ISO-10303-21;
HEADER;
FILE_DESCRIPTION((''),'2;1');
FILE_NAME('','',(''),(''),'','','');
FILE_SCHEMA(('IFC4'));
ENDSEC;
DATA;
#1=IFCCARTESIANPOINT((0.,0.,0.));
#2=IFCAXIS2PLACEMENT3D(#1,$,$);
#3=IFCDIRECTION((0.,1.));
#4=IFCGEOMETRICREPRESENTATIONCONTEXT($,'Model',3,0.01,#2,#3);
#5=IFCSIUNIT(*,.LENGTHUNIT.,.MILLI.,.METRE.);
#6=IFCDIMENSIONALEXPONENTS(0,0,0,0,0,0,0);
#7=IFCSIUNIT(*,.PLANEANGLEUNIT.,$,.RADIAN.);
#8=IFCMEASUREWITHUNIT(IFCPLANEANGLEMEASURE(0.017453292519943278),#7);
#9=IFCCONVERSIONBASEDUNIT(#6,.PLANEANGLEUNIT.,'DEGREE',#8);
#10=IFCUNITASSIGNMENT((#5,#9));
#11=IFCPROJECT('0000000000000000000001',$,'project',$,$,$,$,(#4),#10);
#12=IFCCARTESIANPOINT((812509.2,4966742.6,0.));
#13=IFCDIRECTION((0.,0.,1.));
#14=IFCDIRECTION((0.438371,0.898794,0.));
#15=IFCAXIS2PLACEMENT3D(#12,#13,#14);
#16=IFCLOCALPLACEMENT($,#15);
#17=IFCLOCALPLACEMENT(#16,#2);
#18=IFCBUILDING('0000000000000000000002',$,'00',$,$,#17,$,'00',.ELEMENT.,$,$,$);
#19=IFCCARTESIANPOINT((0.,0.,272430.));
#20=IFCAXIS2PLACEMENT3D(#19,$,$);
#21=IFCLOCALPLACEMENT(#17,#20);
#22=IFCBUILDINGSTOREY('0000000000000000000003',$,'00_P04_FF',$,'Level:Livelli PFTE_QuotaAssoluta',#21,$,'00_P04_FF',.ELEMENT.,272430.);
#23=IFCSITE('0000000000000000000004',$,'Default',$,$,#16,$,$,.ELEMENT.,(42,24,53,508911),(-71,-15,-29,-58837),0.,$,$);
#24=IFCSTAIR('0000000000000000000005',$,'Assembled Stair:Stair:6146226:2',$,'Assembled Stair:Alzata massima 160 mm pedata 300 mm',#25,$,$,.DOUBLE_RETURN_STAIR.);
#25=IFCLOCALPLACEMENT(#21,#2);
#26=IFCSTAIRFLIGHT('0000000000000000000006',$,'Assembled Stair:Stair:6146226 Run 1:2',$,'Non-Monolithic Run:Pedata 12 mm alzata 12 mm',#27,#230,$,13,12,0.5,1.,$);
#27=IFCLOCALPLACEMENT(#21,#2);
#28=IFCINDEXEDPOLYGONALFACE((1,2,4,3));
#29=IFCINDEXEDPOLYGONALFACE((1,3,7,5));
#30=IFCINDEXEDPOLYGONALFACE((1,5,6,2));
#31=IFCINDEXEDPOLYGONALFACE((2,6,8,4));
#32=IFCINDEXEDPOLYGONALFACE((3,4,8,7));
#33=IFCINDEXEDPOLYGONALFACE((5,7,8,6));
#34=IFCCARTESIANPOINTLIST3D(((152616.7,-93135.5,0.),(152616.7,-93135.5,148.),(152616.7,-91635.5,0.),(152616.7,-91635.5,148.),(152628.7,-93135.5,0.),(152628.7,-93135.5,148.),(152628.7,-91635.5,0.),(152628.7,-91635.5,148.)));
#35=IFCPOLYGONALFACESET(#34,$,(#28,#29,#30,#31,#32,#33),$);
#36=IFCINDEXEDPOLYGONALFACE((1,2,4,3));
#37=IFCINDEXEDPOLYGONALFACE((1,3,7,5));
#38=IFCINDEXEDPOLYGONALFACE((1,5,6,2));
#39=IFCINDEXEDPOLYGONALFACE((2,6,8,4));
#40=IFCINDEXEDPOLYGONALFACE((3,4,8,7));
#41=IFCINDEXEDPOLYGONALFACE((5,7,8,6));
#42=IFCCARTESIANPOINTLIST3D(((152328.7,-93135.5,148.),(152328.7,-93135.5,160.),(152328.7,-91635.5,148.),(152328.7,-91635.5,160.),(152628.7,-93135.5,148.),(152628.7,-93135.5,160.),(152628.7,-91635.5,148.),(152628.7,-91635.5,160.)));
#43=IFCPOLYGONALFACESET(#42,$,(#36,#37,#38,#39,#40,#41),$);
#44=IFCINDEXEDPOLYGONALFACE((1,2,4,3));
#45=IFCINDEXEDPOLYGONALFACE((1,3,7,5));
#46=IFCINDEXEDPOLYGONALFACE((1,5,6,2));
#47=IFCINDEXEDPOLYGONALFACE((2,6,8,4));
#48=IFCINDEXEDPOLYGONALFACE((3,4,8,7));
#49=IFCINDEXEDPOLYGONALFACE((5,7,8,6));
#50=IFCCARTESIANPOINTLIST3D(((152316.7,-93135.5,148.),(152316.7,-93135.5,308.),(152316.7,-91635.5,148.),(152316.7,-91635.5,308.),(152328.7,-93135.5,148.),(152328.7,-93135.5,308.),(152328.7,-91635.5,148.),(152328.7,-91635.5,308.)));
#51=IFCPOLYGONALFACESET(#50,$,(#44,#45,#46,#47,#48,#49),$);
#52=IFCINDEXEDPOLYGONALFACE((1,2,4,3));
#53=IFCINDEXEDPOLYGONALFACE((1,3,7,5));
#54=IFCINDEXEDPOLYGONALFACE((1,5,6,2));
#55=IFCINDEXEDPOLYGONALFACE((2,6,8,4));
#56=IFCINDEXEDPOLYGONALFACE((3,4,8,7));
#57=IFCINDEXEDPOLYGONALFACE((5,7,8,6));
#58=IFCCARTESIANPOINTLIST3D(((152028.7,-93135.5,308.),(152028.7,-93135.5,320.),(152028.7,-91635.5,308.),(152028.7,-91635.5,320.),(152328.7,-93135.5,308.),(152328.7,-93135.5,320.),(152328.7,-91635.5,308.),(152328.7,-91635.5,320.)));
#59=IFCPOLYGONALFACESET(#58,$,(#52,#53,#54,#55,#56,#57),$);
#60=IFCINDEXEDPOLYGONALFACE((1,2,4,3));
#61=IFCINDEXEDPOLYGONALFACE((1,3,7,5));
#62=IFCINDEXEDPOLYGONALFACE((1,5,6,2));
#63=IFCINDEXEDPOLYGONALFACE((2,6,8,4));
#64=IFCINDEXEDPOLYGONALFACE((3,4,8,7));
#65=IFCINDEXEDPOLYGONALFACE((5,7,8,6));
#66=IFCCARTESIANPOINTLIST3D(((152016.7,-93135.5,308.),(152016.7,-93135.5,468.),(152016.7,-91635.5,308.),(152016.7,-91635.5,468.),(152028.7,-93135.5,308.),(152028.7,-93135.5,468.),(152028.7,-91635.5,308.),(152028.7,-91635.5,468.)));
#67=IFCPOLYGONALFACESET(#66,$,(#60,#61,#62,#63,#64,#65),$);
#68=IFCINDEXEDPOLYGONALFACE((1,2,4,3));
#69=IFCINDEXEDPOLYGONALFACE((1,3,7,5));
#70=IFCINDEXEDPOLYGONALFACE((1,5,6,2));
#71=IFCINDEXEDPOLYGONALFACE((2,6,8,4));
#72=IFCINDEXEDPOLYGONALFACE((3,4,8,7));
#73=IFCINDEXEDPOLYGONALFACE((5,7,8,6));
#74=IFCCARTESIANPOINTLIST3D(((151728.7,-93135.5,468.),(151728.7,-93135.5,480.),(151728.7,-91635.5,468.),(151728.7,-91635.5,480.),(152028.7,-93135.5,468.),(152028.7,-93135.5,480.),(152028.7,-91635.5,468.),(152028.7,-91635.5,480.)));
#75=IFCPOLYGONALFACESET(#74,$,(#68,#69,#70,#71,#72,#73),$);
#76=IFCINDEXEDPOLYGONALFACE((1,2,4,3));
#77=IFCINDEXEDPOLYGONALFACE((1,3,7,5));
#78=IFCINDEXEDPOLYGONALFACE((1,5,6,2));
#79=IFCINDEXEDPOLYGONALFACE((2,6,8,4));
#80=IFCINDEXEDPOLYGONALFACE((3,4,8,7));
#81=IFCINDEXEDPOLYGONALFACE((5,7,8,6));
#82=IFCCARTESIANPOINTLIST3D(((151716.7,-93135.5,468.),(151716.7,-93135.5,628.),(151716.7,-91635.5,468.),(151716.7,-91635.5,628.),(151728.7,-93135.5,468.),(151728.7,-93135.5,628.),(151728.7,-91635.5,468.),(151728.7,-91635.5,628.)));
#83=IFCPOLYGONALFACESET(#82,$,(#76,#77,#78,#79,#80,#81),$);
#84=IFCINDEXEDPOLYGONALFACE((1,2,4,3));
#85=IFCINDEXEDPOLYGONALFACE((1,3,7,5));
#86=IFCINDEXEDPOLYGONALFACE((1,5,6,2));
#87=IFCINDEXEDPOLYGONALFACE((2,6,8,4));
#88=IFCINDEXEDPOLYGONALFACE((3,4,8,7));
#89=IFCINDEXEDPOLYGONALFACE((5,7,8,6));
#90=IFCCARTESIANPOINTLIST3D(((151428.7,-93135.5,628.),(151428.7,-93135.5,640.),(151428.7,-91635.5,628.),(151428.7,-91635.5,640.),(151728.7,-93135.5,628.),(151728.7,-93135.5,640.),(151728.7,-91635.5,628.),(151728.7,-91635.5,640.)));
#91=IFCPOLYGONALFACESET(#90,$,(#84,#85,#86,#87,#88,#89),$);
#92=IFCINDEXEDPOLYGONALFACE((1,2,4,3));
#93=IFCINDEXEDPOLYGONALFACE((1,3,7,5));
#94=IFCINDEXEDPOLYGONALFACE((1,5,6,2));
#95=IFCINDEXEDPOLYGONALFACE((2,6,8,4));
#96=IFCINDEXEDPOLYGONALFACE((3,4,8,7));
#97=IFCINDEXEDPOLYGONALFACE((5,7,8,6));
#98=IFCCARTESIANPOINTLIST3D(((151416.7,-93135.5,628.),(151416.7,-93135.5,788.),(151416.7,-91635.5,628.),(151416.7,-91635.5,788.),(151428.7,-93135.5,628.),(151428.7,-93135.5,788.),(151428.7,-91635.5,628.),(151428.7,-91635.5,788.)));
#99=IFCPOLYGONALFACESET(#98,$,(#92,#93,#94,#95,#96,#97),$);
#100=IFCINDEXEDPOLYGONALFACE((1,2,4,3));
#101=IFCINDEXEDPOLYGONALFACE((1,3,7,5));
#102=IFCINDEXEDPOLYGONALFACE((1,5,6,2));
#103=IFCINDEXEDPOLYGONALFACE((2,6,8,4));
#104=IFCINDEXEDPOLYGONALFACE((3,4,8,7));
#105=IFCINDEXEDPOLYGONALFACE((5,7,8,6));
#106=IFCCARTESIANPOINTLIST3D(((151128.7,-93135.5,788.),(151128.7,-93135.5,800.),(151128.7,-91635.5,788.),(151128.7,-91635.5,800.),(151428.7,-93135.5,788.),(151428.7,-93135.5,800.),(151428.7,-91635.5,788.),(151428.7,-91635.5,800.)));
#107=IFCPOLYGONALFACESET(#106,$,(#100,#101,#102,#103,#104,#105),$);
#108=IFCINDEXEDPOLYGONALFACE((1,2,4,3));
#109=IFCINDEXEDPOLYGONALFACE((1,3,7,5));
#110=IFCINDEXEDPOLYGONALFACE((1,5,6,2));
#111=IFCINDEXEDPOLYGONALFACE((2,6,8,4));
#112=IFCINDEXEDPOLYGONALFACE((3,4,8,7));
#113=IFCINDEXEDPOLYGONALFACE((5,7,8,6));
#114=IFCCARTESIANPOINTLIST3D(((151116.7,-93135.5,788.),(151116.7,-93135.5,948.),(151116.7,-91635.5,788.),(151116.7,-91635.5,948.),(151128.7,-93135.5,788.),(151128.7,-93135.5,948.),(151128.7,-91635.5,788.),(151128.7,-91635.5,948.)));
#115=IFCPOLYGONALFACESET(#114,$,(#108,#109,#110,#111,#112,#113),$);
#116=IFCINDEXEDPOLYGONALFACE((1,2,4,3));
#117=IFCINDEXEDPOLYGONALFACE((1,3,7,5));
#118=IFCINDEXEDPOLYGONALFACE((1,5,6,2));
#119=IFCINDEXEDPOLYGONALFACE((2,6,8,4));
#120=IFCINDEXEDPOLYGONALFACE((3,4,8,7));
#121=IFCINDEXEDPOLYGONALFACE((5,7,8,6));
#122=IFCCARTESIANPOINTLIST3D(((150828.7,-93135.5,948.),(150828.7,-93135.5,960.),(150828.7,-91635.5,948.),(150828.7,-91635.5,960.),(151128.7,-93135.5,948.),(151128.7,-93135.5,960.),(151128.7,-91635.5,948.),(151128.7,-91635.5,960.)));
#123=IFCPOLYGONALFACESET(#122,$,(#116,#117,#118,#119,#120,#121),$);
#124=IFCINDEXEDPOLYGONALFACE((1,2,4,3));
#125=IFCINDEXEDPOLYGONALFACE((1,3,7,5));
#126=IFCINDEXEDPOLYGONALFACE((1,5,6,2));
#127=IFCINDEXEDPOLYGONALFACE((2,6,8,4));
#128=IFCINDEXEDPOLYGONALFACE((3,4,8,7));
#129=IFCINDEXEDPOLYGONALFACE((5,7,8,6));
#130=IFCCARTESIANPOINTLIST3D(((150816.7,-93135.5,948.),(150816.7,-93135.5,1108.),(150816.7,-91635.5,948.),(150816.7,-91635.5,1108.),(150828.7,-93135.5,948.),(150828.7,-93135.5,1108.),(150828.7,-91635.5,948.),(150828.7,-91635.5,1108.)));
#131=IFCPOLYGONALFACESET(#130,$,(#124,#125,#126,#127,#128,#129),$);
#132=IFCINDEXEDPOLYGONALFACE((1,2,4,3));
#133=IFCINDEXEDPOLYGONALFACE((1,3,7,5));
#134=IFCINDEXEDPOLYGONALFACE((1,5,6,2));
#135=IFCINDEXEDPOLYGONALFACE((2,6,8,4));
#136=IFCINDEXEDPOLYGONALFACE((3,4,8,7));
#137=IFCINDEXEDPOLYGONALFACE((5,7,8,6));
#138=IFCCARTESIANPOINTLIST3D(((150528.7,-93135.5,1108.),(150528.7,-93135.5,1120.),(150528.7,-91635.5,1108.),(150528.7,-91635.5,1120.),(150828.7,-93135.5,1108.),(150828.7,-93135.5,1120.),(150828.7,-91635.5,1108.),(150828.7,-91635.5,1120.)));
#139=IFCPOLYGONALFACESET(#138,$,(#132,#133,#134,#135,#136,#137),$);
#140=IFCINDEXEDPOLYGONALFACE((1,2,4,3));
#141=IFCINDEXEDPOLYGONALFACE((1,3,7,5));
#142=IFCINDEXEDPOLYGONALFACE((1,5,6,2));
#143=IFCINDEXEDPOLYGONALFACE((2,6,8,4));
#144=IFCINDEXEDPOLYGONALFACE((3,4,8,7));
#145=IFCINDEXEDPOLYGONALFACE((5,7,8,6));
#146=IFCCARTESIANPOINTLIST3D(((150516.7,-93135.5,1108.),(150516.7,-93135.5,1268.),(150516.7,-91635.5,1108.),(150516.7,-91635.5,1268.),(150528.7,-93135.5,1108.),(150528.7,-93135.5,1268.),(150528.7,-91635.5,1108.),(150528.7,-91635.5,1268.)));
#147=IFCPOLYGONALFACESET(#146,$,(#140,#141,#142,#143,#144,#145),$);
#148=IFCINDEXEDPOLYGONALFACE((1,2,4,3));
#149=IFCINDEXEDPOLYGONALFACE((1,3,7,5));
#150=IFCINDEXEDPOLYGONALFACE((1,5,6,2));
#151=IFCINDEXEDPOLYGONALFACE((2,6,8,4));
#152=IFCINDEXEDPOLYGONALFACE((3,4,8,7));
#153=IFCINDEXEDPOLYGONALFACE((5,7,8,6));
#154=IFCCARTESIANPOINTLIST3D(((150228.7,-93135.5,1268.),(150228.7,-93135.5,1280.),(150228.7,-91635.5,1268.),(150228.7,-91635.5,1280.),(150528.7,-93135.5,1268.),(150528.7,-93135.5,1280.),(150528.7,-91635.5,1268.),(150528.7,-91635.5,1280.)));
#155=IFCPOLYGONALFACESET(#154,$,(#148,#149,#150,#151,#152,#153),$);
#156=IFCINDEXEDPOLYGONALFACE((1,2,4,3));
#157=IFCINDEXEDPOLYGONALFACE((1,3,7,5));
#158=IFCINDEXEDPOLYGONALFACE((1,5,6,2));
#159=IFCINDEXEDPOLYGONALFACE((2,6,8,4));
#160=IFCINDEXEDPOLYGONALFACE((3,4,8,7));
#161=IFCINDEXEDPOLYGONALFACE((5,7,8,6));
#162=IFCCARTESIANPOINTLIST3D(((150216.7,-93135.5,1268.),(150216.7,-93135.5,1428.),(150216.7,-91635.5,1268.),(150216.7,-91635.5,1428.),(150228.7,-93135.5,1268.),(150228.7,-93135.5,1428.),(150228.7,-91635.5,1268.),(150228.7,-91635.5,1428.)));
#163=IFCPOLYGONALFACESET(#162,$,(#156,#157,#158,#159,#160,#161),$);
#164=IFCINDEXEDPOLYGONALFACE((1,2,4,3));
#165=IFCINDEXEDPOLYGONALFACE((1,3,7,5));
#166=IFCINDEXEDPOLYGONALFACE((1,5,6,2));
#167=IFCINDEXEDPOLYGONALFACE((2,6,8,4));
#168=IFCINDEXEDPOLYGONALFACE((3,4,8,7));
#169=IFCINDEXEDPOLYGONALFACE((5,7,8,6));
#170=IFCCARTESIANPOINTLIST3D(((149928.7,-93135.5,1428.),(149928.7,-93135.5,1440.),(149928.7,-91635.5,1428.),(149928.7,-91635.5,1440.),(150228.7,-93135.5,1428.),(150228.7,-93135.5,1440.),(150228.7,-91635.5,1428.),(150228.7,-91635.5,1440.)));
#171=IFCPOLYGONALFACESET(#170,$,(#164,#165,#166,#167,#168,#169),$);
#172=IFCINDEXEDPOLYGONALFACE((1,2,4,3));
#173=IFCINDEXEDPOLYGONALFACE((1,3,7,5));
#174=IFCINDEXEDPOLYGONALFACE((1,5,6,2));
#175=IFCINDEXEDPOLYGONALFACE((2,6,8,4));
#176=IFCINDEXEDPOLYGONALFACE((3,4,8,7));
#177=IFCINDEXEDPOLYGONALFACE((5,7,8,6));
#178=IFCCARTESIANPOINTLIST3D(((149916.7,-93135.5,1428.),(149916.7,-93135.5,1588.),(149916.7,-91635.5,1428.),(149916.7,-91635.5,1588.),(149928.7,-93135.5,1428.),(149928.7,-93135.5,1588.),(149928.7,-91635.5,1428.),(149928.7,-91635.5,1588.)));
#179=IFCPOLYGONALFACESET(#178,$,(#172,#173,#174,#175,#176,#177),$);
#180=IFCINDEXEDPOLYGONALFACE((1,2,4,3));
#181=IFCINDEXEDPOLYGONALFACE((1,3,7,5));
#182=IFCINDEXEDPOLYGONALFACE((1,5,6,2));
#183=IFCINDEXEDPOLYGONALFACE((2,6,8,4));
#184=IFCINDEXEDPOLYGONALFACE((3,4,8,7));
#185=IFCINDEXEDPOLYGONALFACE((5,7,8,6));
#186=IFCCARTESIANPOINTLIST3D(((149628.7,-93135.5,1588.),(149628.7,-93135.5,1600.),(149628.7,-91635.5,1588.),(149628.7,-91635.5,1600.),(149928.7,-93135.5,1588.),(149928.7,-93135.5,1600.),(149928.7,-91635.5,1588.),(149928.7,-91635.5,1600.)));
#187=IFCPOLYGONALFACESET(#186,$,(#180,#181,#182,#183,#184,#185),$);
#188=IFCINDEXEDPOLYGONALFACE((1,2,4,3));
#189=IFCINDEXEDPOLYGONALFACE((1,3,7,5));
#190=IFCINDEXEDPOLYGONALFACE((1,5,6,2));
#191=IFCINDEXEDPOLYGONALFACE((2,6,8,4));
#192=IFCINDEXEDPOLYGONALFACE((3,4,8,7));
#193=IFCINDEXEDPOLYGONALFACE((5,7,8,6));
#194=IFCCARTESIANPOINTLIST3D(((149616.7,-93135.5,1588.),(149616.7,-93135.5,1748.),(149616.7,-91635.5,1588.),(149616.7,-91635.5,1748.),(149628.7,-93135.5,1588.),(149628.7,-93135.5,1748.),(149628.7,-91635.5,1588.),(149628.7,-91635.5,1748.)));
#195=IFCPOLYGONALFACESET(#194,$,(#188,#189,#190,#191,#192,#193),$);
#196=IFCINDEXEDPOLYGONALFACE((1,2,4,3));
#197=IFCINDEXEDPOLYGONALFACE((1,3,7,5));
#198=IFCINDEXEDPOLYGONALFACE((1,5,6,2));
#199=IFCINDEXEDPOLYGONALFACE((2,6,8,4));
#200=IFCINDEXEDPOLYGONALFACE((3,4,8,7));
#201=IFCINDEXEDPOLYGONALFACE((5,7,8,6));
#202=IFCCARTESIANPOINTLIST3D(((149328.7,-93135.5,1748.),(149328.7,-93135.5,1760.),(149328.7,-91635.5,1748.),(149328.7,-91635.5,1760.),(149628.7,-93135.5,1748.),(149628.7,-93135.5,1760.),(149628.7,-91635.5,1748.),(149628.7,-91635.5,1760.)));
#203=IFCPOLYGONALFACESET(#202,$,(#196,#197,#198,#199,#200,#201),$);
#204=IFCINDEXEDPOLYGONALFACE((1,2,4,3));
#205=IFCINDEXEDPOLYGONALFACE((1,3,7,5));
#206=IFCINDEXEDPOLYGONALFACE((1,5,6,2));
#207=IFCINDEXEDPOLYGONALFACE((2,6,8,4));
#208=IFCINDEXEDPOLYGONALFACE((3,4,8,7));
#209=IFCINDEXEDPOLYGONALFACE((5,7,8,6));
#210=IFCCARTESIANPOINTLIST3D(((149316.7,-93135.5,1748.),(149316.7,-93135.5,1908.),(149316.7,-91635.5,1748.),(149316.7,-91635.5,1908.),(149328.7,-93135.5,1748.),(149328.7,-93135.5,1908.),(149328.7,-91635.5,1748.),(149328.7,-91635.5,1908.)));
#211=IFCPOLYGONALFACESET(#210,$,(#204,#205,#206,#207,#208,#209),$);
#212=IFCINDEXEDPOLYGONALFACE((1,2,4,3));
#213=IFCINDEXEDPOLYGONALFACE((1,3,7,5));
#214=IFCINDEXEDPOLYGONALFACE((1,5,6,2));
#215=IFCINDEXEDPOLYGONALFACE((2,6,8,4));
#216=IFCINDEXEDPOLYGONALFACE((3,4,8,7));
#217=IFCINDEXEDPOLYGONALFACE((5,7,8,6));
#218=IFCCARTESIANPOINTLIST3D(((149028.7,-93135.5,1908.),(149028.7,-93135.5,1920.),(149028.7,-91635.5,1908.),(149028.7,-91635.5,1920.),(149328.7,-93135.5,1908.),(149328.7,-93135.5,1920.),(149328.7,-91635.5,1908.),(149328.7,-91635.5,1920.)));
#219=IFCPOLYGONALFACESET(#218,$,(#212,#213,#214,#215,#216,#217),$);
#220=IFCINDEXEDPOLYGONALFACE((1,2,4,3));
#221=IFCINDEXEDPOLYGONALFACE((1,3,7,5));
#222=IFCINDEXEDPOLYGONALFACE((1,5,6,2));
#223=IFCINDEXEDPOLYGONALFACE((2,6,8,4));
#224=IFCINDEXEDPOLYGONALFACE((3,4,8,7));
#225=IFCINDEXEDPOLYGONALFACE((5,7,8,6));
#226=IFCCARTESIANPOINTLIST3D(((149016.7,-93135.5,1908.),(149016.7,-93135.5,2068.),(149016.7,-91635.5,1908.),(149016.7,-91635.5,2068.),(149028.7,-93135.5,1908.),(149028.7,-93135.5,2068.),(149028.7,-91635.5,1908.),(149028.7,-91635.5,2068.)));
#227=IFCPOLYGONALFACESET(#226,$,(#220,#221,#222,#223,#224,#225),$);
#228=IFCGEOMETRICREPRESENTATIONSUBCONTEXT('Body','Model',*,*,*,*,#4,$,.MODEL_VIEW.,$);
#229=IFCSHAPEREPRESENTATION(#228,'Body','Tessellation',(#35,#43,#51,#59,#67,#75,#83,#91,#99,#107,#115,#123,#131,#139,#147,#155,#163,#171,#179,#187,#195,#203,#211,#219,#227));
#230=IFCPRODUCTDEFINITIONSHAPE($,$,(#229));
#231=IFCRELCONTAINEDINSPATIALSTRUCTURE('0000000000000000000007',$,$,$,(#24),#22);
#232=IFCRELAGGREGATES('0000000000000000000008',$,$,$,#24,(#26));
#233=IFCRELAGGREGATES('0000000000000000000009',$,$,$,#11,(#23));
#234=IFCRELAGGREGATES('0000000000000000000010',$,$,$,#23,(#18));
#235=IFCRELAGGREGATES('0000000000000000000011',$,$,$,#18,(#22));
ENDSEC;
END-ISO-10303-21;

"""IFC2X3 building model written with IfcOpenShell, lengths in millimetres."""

from ifc_helpers import new_model, entity, si_unit, converted_unit, direction, frame, frame_2d, origin, origin_2d_with_axis, place, context, subcontext, project, spatial, rectangle, extrude, element, aggregate, save


model = new_model("IFC2X3")

# Units and contexts
model_context = context("Model", 3, precision=0.01, world=origin(), true_north=direction((0.0, 1.0)))
body_context = subcontext(model_context, "Body", "Model", "MODEL_VIEW")
ifc_project = project(units=[si_unit("LENGTHUNIT", "METRE", prefix="MILLI"), converted_unit("PLANEANGLEUNIT", "DEGREE", entity("IfcPlaneAngleMeasure", 0.017453292519943278), si_unit("PLANEANGLEUNIT", "RADIAN"), dimensions=[0, 0, 0, 0, 0, 0, 0])], contexts=[model_context])

# Site, building, storey
site_placement = place(None, frame((812509.2, 4966742.6, 0.0), z_axis=(0.0, 0.0, 1.0), x_axis=(0.438371, 0.898794, 0.0)))
site = spatial("IfcSite", under=ifc_project, at=site_placement, Name="Default", CompositionType="ELEMENT", RefLatitude=(42, 24, 53, 508911), RefLongitude=(-71, -15, -29, -58837), RefElevation=0.0)
building_placement = place(site_placement, origin())
building = spatial("IfcBuilding", under=site, at=building_placement, Name="00", LongName="00", CompositionType="ELEMENT")
storey_placement = place(building_placement, frame((0.0, 0.0, 272430.0)))
storey = spatial("IfcBuildingStorey", under=building, at=storey_placement, Name="00_P04_FF", ObjectType="Level:Livelli PFTE_QuotaAssoluta", LongName="00_P04_FF", CompositionType="ELEMENT", Elevation=272430.0)

# Stair
stair_1_placement = place(storey_placement, origin())
stair_1 = element("IfcStair", 1, at=stair_1_placement, inside=storey, Name="Assembled Stair:Stair:6146226:2", ObjectType="Assembled Stair:Alzata massima 160 mm pedata 300 mm", ShapeType="DOUBLE_RETURN_STAIR")

# Stair flight
stair_flight_1_placement = place(stair_1_placement, origin())
stair_flight_1 = element("IfcStairFlight", 2, at=stair_flight_1_placement, Name="Assembled Stair:Stair:6146226 Run 1:2", ObjectType="Non-Monolithic Run:Pedata 12 mm alzata 12 mm", NumberOfRiser=13, NumberOfTreads=12, RiserHeight=0.5, TreadLength=1.0, context=body_context, shape_type="SweptSolid", body=[
    extrude(rectangle(XDim=1500.0, YDim=12.0, at=frame_2d((0.0, 0.0), x_axis=(1.0, 0.0))), frame((152622.7, -92385.5, 0.0), z_axis=(0.0, 0.0, 1.0), x_axis=(0.0, -1.0, 0.0)), (0.0, 0.0, 1.0), 148.0),
    extrude(rectangle(XDim=300.0, YDim=1500.0, at=frame_2d((0.0, 0.0), x_axis=(1.0, 0.0))), frame((152478.7, -92385.5, 148.0)), (0.0, 0.0, 1.0), 12.0),
    extrude(rectangle(XDim=1500.0, YDim=12.0, at=origin_2d_with_axis()), frame((152322.7, -92385.5, 148.0), z_axis=(0.0, 0.0, 1.0), x_axis=(0.0, -1.0, 0.0)), (0.0, 0.0, 1.0), 160.0),
    extrude(rectangle(XDim=300.0, YDim=1500.0, at=origin_2d_with_axis()), frame((152178.7, -92385.5, 308.0)), (0.0, 0.0, 1.0), 12.0),
    extrude(rectangle(XDim=1500.0, YDim=12.0, at=origin_2d_with_axis()), frame((152022.7, -92385.5, 308.0), z_axis=(0.0, 0.0, 1.0), x_axis=(0.0, -1.0, 0.0)), (0.0, 0.0, 1.0), 160.0),
    extrude(rectangle(XDim=300.0, YDim=1500.0, at=origin_2d_with_axis()), frame((151878.7, -92385.5, 468.0)), (0.0, 0.0, 1.0), 12.0),
    extrude(rectangle(XDim=1500.0, YDim=12.0, at=origin_2d_with_axis()), frame((151722.7, -92385.5, 468.0), z_axis=(0.0, 0.0, 1.0), x_axis=(0.0, -1.0, 0.0)), (0.0, 0.0, 1.0), 160.0),
    extrude(rectangle(XDim=300.0, YDim=1500.0, at=origin_2d_with_axis()), frame((151578.7, -92385.5, 628.0)), (0.0, 0.0, 1.0), 12.0),
    extrude(rectangle(XDim=1500.0, YDim=12.0, at=origin_2d_with_axis()), frame((151422.7, -92385.5, 628.0), z_axis=(0.0, 0.0, 1.0), x_axis=(0.0, -1.0, 0.0)), (0.0, 0.0, 1.0), 160.0),
    extrude(rectangle(XDim=300.0, YDim=1500.0, at=origin_2d_with_axis()), frame((151278.7, -92385.5, 788.0)), (0.0, 0.0, 1.0), 12.0),
    extrude(rectangle(XDim=1500.0, YDim=12.0, at=origin_2d_with_axis()), frame((151122.7, -92385.5, 788.0), z_axis=(0.0, 0.0, 1.0), x_axis=(0.0, -1.0, 0.0)), (0.0, 0.0, 1.0), 160.0),
    extrude(rectangle(XDim=300.0, YDim=1500.0, at=origin_2d_with_axis()), frame((150978.7, -92385.5, 948.0)), (0.0, 0.0, 1.0), 12.0),
    extrude(rectangle(XDim=1500.0, YDim=12.0, at=origin_2d_with_axis()), frame((150822.7, -92385.5, 948.0), z_axis=(0.0, 0.0, 1.0), x_axis=(0.0, -1.0, 0.0)), (0.0, 0.0, 1.0), 160.0),
    extrude(rectangle(XDim=300.0, YDim=1500.0, at=origin_2d_with_axis()), frame((150678.7, -92385.5, 1108.0)), (0.0, 0.0, 1.0), 12.0),
    extrude(rectangle(XDim=1500.0, YDim=12.0, at=origin_2d_with_axis()), frame((150522.7, -92385.5, 1108.0), z_axis=(0.0, 0.0, 1.0), x_axis=(0.0, -1.0, 0.0)), (0.0, 0.0, 1.0), 160.0),
    extrude(rectangle(XDim=300.0, YDim=1500.0, at=origin_2d_with_axis()), frame((150378.7, -92385.5, 1268.0)), (0.0, 0.0, 1.0), 12.0),
    extrude(rectangle(XDim=1500.0, YDim=12.0, at=origin_2d_with_axis()), frame((150222.7, -92385.5, 1268.0), z_axis=(0.0, 0.0, 1.0), x_axis=(0.0, -1.0, 0.0)), (0.0, 0.0, 1.0), 160.0),
    extrude(rectangle(XDim=300.0, YDim=1500.0, at=origin_2d_with_axis()), frame((150078.7, -92385.5, 1428.0)), (0.0, 0.0, 1.0), 12.0),
    extrude(rectangle(XDim=1500.0, YDim=12.0, at=origin_2d_with_axis()), frame((149922.7, -92385.5, 1428.0), z_axis=(0.0, 0.0, 1.0), x_axis=(0.0, -1.0, 0.0)), (0.0, 0.0, 1.0), 160.0),
    extrude(rectangle(XDim=300.0, YDim=1500.0, at=origin_2d_with_axis()), frame((149778.7, -92385.5, 1588.0)), (0.0, 0.0, 1.0), 12.0),
    extrude(rectangle(XDim=1500.0, YDim=12.0, at=origin_2d_with_axis()), frame((149622.7, -92385.5, 1588.0), z_axis=(0.0, 0.0, 1.0), x_axis=(0.0, -1.0, 0.0)), (0.0, 0.0, 1.0), 160.0),
    extrude(rectangle(XDim=300.0, YDim=1500.0, at=origin_2d_with_axis()), frame((149478.7, -92385.5, 1748.0)), (0.0, 0.0, 1.0), 12.0),
    extrude(rectangle(XDim=1500.0, YDim=12.0, at=origin_2d_with_axis()), frame((149322.7, -92385.5, 1748.0), z_axis=(0.0, 0.0, 1.0), x_axis=(0.0, -1.0, 0.0)), (0.0, 0.0, 1.0), 160.0),
    extrude(rectangle(XDim=300.0, YDim=1500.0, at=origin_2d_with_axis()), frame((149178.7, -92385.5, 1908.0)), (0.0, 0.0, 1.0), 12.0),
    extrude(rectangle(XDim=1500.0, YDim=12.0, at=origin_2d_with_axis()), frame((149022.7, -92385.5, 1908.0), z_axis=(0.0, 0.0, 1.0), x_axis=(0.0, -1.0, 0.0)), (0.0, 0.0, 1.0), 160.0),
])
aggregate(stair_1, [stair_flight_1])

save(model, "model.ifc")
